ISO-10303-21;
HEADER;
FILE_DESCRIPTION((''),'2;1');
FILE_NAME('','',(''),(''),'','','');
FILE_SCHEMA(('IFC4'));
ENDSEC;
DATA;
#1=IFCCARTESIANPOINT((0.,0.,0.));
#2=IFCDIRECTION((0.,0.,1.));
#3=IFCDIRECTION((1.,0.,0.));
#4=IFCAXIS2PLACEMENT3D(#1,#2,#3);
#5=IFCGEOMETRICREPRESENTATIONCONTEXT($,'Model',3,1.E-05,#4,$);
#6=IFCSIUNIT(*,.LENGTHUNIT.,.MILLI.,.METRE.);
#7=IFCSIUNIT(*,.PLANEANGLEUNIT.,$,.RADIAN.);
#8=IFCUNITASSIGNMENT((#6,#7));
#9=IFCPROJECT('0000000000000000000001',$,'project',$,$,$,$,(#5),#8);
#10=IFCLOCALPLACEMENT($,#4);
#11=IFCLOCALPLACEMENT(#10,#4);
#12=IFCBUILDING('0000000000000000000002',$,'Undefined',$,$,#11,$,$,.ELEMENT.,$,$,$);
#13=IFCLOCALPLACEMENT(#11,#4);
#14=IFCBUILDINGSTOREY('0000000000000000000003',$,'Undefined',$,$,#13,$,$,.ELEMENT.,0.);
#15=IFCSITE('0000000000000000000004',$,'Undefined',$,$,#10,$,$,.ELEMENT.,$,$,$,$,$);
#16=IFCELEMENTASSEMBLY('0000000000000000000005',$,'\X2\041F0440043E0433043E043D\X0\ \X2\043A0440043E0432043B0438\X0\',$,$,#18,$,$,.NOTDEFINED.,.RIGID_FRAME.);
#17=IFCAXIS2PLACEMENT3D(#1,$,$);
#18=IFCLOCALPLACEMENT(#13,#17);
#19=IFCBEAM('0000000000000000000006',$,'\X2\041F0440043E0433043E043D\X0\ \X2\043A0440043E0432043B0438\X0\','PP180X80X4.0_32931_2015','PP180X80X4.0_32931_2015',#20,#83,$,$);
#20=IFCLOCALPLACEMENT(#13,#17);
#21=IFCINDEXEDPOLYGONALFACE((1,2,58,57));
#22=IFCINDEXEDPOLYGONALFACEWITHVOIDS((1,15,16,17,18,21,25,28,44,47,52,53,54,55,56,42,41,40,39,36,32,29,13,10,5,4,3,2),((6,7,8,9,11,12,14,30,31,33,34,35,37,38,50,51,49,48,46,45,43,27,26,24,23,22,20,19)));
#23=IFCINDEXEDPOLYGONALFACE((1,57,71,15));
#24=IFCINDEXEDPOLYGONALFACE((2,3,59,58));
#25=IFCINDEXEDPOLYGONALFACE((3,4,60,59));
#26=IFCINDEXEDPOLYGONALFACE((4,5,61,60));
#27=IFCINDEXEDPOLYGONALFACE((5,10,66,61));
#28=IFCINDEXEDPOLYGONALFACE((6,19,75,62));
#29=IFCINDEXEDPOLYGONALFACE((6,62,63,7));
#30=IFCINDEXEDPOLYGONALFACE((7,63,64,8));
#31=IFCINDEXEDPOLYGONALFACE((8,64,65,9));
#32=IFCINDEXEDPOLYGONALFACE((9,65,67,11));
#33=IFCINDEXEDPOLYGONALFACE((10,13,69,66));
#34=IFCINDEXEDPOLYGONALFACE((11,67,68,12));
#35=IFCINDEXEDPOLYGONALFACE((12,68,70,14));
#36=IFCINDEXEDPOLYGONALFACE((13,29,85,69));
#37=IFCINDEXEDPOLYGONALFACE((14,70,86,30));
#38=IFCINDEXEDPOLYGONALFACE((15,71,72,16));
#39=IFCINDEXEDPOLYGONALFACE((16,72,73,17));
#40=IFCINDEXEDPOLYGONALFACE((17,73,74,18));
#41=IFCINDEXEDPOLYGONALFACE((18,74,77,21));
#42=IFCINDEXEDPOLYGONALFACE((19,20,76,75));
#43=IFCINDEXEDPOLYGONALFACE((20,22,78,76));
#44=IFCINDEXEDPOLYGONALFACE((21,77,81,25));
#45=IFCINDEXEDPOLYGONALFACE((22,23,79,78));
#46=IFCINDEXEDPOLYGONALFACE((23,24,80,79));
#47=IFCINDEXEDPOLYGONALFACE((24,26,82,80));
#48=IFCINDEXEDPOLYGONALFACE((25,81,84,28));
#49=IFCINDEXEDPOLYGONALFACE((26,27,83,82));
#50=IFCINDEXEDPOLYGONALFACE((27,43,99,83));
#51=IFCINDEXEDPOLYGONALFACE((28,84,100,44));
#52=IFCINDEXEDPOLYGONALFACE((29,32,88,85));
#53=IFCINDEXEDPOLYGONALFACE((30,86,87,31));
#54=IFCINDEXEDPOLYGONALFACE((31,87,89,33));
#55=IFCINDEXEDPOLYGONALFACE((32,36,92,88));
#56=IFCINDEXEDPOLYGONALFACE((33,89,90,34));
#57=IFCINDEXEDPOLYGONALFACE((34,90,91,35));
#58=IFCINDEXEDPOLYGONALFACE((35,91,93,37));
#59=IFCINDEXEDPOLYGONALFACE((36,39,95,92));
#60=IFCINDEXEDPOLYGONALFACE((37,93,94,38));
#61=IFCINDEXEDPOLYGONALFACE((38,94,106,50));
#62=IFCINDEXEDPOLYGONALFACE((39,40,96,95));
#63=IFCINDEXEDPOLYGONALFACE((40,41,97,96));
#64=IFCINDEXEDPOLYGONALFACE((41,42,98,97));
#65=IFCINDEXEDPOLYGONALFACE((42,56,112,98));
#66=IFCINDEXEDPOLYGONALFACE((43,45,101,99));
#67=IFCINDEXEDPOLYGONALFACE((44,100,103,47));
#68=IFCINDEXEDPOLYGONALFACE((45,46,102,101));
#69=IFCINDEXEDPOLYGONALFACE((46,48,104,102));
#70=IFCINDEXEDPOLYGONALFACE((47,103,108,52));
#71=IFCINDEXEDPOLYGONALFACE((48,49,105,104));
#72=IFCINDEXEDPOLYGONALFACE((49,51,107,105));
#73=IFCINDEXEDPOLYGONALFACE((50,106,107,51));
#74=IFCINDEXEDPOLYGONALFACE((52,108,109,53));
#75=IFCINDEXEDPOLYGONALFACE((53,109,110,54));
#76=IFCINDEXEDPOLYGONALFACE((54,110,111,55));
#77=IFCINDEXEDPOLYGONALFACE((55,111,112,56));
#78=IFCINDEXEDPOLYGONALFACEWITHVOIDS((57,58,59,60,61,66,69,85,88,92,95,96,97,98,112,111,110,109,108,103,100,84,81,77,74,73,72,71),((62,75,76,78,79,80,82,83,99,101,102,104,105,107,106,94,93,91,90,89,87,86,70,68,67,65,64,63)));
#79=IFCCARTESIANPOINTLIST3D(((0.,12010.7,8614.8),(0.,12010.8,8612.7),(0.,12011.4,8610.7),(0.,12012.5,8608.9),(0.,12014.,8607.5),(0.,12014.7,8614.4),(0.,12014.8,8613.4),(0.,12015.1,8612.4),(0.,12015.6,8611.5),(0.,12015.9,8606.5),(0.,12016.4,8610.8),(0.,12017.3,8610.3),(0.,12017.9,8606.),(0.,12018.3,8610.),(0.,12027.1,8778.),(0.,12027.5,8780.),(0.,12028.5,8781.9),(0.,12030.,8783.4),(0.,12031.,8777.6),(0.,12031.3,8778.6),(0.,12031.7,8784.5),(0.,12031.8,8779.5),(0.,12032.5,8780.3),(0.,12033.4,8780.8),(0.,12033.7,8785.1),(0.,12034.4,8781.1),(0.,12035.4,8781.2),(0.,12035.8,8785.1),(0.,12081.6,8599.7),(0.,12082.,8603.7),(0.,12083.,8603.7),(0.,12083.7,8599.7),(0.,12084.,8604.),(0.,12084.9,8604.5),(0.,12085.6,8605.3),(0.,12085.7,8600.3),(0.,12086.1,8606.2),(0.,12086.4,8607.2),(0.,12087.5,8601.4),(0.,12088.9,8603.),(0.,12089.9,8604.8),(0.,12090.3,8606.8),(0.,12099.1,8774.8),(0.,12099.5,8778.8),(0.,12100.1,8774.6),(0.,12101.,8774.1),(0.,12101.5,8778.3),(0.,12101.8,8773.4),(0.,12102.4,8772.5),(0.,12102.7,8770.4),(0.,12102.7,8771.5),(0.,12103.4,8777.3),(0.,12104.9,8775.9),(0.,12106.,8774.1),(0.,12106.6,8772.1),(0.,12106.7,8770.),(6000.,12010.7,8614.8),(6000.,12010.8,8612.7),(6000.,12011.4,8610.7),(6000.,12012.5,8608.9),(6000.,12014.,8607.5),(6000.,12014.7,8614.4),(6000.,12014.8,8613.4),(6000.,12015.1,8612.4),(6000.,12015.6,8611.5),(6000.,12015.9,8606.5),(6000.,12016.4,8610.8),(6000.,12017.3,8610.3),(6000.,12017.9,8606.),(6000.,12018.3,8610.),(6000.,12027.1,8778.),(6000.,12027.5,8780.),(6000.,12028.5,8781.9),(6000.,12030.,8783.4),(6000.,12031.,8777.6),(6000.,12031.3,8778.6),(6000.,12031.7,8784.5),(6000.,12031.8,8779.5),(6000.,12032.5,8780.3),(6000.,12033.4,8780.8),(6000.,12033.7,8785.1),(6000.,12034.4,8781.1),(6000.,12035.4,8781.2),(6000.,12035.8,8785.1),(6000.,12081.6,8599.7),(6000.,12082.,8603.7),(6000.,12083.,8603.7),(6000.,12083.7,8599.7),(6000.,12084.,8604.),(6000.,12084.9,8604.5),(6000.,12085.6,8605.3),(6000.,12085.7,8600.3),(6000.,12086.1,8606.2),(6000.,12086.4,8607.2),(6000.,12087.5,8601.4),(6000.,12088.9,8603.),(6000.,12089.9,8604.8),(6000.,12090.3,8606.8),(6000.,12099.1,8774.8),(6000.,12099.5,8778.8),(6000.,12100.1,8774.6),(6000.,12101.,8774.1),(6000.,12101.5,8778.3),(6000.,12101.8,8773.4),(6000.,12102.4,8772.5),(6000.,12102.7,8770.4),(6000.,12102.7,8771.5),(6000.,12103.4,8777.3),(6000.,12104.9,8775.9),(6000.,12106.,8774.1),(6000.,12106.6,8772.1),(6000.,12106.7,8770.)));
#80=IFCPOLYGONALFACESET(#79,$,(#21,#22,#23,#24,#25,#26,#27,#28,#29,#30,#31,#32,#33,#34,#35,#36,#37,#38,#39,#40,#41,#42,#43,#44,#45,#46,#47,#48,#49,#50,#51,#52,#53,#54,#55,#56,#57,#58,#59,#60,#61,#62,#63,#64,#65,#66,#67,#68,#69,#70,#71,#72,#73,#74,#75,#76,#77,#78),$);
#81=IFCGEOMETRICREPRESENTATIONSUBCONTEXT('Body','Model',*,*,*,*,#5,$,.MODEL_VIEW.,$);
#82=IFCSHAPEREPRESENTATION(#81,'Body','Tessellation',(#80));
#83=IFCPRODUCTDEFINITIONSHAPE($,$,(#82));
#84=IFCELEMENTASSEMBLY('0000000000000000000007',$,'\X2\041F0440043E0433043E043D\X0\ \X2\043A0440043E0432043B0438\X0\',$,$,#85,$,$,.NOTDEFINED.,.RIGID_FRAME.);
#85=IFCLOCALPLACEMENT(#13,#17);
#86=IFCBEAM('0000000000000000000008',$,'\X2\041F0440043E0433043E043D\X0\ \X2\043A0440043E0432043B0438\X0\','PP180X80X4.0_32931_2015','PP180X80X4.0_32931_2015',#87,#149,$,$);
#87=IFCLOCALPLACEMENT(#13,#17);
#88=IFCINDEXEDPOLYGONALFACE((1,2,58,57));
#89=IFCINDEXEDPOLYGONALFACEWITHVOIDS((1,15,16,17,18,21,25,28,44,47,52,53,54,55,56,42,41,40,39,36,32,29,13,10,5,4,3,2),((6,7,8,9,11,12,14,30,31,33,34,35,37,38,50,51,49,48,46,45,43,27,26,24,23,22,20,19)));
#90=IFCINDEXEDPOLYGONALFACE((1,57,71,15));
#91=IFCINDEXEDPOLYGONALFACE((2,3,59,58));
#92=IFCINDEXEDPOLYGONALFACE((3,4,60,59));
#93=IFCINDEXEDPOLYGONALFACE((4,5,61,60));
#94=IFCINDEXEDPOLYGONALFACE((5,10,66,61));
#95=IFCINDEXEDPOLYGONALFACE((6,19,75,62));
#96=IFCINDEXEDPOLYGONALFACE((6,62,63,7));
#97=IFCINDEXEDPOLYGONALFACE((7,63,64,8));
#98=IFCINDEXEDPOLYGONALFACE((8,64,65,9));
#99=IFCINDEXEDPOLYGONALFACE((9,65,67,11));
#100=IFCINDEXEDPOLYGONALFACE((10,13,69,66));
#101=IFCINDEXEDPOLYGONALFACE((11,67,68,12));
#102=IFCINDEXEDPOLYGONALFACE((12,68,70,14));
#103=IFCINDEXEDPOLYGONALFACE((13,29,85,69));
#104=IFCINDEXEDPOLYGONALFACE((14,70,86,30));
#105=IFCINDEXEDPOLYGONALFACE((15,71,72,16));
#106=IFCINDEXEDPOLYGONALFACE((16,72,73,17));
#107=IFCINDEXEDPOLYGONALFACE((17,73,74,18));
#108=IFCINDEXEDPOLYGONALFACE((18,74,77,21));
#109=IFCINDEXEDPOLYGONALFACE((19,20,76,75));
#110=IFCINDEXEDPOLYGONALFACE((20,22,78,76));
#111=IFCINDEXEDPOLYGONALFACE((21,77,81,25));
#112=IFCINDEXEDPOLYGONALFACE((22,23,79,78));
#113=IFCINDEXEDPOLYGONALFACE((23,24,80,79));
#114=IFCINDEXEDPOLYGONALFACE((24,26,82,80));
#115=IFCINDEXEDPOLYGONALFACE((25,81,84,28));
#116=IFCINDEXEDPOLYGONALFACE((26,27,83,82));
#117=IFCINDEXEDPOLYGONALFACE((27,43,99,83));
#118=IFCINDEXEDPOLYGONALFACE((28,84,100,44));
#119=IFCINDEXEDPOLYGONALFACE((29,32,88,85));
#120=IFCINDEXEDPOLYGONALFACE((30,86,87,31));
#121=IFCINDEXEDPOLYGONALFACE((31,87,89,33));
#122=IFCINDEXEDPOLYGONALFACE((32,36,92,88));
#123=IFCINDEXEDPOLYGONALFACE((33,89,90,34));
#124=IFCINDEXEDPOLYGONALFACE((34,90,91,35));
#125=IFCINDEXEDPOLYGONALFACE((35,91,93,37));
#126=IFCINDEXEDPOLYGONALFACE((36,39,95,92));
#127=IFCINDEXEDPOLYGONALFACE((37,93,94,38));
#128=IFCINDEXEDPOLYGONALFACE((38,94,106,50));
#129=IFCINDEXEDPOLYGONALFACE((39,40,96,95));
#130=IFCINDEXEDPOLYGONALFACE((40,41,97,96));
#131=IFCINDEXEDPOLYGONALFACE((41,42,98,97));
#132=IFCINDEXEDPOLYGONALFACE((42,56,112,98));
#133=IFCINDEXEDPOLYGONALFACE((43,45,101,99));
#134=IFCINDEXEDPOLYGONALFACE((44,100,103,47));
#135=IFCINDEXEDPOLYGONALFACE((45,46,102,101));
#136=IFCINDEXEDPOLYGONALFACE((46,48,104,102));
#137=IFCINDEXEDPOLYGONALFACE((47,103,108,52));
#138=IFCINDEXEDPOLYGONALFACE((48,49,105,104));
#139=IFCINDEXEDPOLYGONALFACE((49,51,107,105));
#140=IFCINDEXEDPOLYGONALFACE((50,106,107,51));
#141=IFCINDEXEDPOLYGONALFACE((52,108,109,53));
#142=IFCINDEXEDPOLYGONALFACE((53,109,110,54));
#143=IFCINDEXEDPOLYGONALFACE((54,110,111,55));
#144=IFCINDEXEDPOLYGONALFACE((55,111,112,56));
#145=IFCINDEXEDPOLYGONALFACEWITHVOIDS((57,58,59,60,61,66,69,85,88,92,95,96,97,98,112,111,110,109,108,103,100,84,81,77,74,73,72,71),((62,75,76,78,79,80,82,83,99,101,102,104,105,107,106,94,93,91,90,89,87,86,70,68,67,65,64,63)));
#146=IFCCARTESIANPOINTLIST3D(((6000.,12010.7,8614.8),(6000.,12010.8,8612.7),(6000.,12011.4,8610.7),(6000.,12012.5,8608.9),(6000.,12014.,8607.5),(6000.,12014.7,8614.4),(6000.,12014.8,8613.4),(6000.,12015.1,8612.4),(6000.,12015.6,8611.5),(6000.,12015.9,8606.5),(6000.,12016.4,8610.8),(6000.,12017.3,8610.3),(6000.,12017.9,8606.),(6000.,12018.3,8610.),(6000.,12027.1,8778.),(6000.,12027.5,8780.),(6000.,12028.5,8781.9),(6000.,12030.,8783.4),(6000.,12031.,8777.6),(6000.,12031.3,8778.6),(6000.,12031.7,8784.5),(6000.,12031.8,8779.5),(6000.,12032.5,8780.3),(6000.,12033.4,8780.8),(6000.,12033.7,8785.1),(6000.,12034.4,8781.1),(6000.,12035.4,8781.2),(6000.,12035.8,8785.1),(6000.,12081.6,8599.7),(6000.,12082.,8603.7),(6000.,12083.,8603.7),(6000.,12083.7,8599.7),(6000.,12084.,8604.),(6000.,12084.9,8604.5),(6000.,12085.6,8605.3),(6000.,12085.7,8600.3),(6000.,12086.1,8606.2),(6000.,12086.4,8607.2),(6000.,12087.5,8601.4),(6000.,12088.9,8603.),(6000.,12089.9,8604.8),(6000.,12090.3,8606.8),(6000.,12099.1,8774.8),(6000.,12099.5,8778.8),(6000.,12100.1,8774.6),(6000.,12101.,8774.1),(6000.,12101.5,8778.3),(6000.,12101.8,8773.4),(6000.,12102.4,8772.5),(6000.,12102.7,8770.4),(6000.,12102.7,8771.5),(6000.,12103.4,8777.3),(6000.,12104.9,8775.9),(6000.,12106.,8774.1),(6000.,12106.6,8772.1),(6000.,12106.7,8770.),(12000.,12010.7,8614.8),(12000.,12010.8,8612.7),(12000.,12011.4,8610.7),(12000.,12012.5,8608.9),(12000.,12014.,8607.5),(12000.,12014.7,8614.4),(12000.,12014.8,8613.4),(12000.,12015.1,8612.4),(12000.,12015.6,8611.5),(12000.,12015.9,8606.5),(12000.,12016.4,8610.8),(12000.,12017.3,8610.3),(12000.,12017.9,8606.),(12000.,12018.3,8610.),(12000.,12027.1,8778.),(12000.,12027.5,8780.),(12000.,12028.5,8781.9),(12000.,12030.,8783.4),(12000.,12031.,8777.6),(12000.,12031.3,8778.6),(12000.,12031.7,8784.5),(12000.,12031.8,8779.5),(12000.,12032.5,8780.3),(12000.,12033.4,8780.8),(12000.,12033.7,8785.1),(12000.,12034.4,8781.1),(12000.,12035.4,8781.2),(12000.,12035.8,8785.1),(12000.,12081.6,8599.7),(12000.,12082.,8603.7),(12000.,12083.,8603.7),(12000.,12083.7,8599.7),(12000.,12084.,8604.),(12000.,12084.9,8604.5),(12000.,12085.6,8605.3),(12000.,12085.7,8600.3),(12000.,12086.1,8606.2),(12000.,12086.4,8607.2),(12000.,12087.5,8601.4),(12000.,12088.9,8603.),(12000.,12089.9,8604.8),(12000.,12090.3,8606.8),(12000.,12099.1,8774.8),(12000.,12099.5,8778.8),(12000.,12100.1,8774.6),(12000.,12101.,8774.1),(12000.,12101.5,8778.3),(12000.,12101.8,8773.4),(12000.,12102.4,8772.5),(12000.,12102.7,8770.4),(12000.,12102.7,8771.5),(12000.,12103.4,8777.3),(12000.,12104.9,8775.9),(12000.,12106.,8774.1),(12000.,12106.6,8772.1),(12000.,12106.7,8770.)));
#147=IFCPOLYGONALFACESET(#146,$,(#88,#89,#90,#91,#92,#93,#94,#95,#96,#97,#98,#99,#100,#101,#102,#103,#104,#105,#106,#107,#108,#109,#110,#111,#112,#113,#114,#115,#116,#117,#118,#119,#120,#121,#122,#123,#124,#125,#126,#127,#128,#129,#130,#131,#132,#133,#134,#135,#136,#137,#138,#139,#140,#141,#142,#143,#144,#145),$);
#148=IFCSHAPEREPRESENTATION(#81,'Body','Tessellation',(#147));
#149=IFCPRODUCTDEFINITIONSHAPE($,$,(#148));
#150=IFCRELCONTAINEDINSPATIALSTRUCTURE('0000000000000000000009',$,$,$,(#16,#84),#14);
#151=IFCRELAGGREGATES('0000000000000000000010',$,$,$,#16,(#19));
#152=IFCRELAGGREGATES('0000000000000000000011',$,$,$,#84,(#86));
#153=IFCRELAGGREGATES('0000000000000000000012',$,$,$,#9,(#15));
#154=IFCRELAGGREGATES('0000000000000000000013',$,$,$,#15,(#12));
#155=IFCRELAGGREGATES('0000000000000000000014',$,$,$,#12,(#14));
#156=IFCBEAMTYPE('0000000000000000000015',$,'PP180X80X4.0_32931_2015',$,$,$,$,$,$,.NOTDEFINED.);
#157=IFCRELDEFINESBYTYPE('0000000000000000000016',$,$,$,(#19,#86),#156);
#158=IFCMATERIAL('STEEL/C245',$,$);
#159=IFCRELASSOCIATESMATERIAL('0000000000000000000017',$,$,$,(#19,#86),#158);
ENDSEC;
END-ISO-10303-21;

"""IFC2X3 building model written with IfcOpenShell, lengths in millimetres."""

from ifc_helpers import new_model, si_unit, frame, origin_with_axes, origin_2d_with_axis, place, context, subcontext, project, spatial, hollow_rectangle, extrude, material, type_object, element, aggregate, save


model = new_model("IFC2X3")

# Units and contexts
model_context = context("Model", 3, precision=1e-05, world=origin_with_axes())
body_context = subcontext(model_context, "Body", "Model", "MODEL_VIEW")
ifc_project = project(units=[si_unit("LENGTHUNIT", "METRE", prefix="MILLI"), si_unit("PLANEANGLEUNIT", "RADIAN")], contexts=[model_context])

# Site, building, storey
site_placement = place(None, origin_with_axes())
site = spatial("IfcSite", under=ifc_project, at=site_placement, Name="Undefined", CompositionType="ELEMENT")
building_placement = place(site_placement, origin_with_axes())
building = spatial("IfcBuilding", under=site, at=building_placement, Name="Undefined", CompositionType="ELEMENT")
storey_placement = place(building_placement, origin_with_axes())
storey = spatial("IfcBuildingStorey", under=building, at=storey_placement, Name="Undefined", CompositionType="ELEMENT", Elevation=0.0)

# Shared definitions
ifc_material_1 = material(Name="STEEL/C245")

# Element assemblies, beams
assembly_1_placement = place(storey_placement, origin_with_axes())
assembly_1 = element("IfcElementAssembly", 1, at=assembly_1_placement, inside=storey, Name="Прогон кровли", AssemblyPlace="NOTDEFINED", PredefinedType="RIGID_FRAME")
beam_type_1 = type_object("IfcBeamType", Name="PP180X80X4.0_32931_2015", PredefinedType="NOTDEFINED")
beam_1_placement = place(assembly_1_placement, frame((0.0, 12058.7, 8692.4), z_axis=(0.0, 0.099504, 0.995037), x_axis=(1.0, 0.0, 0.0)))
beam_1 = element("IfcBeam", 2, at=beam_1_placement, type_object=beam_type_1, material=ifc_material_1, Name="Прогон кровли", Description="PP180X80X4.0_32931_2015", ObjectType="PP180X80X4.0_32931_2015", context=body_context, shape_type="SweptSolid", body=[
    extrude(hollow_rectangle(XDim=80.0, YDim=180.0, WallThickness=4.0, InnerFilletRadius=4.0, OuterFilletRadius=8.0, at=origin_2d_with_axis()), frame((6000.0, 0.0, 0.0), z_axis=(-1.0, 0.0, 0.0), x_axis=(0.0, -1.0, 0.0)), (0.0, 0.0, 1.0), 6000.0),
])
aggregate(assembly_1, [beam_1])
assembly_2_placement = place(storey_placement, origin_with_axes())
assembly_2 = element("IfcElementAssembly", 3, at=assembly_2_placement, inside=storey, Name="Прогон кровли", AssemblyPlace="NOTDEFINED", PredefinedType="RIGID_FRAME")
beam_2_placement = place(assembly_2_placement, frame((6000.0, 12058.7, 8692.4), z_axis=(0.0, 0.099504, 0.995037), x_axis=(1.0, 0.0, 0.0)))
beam_2 = element("IfcBeam", 4, at=beam_2_placement, type_object=beam_type_1, material=ifc_material_1, Name="Прогон кровли", Description="PP180X80X4.0_32931_2015", ObjectType="PP180X80X4.0_32931_2015", context=body_context, shape_type="SweptSolid", body=[
    extrude(hollow_rectangle(XDim=80.0, YDim=180.0, WallThickness=4.0, InnerFilletRadius=4.0, OuterFilletRadius=8.0, at=origin_2d_with_axis()), frame((6000.0, 0.0, 0.0), z_axis=(-1.0, 0.0, 0.0), x_axis=(0.0, -1.0, 0.0)), (0.0, 0.0, 1.0), 6000.0),
])
aggregate(assembly_2, [beam_2])

save(model, "model.ifc")
